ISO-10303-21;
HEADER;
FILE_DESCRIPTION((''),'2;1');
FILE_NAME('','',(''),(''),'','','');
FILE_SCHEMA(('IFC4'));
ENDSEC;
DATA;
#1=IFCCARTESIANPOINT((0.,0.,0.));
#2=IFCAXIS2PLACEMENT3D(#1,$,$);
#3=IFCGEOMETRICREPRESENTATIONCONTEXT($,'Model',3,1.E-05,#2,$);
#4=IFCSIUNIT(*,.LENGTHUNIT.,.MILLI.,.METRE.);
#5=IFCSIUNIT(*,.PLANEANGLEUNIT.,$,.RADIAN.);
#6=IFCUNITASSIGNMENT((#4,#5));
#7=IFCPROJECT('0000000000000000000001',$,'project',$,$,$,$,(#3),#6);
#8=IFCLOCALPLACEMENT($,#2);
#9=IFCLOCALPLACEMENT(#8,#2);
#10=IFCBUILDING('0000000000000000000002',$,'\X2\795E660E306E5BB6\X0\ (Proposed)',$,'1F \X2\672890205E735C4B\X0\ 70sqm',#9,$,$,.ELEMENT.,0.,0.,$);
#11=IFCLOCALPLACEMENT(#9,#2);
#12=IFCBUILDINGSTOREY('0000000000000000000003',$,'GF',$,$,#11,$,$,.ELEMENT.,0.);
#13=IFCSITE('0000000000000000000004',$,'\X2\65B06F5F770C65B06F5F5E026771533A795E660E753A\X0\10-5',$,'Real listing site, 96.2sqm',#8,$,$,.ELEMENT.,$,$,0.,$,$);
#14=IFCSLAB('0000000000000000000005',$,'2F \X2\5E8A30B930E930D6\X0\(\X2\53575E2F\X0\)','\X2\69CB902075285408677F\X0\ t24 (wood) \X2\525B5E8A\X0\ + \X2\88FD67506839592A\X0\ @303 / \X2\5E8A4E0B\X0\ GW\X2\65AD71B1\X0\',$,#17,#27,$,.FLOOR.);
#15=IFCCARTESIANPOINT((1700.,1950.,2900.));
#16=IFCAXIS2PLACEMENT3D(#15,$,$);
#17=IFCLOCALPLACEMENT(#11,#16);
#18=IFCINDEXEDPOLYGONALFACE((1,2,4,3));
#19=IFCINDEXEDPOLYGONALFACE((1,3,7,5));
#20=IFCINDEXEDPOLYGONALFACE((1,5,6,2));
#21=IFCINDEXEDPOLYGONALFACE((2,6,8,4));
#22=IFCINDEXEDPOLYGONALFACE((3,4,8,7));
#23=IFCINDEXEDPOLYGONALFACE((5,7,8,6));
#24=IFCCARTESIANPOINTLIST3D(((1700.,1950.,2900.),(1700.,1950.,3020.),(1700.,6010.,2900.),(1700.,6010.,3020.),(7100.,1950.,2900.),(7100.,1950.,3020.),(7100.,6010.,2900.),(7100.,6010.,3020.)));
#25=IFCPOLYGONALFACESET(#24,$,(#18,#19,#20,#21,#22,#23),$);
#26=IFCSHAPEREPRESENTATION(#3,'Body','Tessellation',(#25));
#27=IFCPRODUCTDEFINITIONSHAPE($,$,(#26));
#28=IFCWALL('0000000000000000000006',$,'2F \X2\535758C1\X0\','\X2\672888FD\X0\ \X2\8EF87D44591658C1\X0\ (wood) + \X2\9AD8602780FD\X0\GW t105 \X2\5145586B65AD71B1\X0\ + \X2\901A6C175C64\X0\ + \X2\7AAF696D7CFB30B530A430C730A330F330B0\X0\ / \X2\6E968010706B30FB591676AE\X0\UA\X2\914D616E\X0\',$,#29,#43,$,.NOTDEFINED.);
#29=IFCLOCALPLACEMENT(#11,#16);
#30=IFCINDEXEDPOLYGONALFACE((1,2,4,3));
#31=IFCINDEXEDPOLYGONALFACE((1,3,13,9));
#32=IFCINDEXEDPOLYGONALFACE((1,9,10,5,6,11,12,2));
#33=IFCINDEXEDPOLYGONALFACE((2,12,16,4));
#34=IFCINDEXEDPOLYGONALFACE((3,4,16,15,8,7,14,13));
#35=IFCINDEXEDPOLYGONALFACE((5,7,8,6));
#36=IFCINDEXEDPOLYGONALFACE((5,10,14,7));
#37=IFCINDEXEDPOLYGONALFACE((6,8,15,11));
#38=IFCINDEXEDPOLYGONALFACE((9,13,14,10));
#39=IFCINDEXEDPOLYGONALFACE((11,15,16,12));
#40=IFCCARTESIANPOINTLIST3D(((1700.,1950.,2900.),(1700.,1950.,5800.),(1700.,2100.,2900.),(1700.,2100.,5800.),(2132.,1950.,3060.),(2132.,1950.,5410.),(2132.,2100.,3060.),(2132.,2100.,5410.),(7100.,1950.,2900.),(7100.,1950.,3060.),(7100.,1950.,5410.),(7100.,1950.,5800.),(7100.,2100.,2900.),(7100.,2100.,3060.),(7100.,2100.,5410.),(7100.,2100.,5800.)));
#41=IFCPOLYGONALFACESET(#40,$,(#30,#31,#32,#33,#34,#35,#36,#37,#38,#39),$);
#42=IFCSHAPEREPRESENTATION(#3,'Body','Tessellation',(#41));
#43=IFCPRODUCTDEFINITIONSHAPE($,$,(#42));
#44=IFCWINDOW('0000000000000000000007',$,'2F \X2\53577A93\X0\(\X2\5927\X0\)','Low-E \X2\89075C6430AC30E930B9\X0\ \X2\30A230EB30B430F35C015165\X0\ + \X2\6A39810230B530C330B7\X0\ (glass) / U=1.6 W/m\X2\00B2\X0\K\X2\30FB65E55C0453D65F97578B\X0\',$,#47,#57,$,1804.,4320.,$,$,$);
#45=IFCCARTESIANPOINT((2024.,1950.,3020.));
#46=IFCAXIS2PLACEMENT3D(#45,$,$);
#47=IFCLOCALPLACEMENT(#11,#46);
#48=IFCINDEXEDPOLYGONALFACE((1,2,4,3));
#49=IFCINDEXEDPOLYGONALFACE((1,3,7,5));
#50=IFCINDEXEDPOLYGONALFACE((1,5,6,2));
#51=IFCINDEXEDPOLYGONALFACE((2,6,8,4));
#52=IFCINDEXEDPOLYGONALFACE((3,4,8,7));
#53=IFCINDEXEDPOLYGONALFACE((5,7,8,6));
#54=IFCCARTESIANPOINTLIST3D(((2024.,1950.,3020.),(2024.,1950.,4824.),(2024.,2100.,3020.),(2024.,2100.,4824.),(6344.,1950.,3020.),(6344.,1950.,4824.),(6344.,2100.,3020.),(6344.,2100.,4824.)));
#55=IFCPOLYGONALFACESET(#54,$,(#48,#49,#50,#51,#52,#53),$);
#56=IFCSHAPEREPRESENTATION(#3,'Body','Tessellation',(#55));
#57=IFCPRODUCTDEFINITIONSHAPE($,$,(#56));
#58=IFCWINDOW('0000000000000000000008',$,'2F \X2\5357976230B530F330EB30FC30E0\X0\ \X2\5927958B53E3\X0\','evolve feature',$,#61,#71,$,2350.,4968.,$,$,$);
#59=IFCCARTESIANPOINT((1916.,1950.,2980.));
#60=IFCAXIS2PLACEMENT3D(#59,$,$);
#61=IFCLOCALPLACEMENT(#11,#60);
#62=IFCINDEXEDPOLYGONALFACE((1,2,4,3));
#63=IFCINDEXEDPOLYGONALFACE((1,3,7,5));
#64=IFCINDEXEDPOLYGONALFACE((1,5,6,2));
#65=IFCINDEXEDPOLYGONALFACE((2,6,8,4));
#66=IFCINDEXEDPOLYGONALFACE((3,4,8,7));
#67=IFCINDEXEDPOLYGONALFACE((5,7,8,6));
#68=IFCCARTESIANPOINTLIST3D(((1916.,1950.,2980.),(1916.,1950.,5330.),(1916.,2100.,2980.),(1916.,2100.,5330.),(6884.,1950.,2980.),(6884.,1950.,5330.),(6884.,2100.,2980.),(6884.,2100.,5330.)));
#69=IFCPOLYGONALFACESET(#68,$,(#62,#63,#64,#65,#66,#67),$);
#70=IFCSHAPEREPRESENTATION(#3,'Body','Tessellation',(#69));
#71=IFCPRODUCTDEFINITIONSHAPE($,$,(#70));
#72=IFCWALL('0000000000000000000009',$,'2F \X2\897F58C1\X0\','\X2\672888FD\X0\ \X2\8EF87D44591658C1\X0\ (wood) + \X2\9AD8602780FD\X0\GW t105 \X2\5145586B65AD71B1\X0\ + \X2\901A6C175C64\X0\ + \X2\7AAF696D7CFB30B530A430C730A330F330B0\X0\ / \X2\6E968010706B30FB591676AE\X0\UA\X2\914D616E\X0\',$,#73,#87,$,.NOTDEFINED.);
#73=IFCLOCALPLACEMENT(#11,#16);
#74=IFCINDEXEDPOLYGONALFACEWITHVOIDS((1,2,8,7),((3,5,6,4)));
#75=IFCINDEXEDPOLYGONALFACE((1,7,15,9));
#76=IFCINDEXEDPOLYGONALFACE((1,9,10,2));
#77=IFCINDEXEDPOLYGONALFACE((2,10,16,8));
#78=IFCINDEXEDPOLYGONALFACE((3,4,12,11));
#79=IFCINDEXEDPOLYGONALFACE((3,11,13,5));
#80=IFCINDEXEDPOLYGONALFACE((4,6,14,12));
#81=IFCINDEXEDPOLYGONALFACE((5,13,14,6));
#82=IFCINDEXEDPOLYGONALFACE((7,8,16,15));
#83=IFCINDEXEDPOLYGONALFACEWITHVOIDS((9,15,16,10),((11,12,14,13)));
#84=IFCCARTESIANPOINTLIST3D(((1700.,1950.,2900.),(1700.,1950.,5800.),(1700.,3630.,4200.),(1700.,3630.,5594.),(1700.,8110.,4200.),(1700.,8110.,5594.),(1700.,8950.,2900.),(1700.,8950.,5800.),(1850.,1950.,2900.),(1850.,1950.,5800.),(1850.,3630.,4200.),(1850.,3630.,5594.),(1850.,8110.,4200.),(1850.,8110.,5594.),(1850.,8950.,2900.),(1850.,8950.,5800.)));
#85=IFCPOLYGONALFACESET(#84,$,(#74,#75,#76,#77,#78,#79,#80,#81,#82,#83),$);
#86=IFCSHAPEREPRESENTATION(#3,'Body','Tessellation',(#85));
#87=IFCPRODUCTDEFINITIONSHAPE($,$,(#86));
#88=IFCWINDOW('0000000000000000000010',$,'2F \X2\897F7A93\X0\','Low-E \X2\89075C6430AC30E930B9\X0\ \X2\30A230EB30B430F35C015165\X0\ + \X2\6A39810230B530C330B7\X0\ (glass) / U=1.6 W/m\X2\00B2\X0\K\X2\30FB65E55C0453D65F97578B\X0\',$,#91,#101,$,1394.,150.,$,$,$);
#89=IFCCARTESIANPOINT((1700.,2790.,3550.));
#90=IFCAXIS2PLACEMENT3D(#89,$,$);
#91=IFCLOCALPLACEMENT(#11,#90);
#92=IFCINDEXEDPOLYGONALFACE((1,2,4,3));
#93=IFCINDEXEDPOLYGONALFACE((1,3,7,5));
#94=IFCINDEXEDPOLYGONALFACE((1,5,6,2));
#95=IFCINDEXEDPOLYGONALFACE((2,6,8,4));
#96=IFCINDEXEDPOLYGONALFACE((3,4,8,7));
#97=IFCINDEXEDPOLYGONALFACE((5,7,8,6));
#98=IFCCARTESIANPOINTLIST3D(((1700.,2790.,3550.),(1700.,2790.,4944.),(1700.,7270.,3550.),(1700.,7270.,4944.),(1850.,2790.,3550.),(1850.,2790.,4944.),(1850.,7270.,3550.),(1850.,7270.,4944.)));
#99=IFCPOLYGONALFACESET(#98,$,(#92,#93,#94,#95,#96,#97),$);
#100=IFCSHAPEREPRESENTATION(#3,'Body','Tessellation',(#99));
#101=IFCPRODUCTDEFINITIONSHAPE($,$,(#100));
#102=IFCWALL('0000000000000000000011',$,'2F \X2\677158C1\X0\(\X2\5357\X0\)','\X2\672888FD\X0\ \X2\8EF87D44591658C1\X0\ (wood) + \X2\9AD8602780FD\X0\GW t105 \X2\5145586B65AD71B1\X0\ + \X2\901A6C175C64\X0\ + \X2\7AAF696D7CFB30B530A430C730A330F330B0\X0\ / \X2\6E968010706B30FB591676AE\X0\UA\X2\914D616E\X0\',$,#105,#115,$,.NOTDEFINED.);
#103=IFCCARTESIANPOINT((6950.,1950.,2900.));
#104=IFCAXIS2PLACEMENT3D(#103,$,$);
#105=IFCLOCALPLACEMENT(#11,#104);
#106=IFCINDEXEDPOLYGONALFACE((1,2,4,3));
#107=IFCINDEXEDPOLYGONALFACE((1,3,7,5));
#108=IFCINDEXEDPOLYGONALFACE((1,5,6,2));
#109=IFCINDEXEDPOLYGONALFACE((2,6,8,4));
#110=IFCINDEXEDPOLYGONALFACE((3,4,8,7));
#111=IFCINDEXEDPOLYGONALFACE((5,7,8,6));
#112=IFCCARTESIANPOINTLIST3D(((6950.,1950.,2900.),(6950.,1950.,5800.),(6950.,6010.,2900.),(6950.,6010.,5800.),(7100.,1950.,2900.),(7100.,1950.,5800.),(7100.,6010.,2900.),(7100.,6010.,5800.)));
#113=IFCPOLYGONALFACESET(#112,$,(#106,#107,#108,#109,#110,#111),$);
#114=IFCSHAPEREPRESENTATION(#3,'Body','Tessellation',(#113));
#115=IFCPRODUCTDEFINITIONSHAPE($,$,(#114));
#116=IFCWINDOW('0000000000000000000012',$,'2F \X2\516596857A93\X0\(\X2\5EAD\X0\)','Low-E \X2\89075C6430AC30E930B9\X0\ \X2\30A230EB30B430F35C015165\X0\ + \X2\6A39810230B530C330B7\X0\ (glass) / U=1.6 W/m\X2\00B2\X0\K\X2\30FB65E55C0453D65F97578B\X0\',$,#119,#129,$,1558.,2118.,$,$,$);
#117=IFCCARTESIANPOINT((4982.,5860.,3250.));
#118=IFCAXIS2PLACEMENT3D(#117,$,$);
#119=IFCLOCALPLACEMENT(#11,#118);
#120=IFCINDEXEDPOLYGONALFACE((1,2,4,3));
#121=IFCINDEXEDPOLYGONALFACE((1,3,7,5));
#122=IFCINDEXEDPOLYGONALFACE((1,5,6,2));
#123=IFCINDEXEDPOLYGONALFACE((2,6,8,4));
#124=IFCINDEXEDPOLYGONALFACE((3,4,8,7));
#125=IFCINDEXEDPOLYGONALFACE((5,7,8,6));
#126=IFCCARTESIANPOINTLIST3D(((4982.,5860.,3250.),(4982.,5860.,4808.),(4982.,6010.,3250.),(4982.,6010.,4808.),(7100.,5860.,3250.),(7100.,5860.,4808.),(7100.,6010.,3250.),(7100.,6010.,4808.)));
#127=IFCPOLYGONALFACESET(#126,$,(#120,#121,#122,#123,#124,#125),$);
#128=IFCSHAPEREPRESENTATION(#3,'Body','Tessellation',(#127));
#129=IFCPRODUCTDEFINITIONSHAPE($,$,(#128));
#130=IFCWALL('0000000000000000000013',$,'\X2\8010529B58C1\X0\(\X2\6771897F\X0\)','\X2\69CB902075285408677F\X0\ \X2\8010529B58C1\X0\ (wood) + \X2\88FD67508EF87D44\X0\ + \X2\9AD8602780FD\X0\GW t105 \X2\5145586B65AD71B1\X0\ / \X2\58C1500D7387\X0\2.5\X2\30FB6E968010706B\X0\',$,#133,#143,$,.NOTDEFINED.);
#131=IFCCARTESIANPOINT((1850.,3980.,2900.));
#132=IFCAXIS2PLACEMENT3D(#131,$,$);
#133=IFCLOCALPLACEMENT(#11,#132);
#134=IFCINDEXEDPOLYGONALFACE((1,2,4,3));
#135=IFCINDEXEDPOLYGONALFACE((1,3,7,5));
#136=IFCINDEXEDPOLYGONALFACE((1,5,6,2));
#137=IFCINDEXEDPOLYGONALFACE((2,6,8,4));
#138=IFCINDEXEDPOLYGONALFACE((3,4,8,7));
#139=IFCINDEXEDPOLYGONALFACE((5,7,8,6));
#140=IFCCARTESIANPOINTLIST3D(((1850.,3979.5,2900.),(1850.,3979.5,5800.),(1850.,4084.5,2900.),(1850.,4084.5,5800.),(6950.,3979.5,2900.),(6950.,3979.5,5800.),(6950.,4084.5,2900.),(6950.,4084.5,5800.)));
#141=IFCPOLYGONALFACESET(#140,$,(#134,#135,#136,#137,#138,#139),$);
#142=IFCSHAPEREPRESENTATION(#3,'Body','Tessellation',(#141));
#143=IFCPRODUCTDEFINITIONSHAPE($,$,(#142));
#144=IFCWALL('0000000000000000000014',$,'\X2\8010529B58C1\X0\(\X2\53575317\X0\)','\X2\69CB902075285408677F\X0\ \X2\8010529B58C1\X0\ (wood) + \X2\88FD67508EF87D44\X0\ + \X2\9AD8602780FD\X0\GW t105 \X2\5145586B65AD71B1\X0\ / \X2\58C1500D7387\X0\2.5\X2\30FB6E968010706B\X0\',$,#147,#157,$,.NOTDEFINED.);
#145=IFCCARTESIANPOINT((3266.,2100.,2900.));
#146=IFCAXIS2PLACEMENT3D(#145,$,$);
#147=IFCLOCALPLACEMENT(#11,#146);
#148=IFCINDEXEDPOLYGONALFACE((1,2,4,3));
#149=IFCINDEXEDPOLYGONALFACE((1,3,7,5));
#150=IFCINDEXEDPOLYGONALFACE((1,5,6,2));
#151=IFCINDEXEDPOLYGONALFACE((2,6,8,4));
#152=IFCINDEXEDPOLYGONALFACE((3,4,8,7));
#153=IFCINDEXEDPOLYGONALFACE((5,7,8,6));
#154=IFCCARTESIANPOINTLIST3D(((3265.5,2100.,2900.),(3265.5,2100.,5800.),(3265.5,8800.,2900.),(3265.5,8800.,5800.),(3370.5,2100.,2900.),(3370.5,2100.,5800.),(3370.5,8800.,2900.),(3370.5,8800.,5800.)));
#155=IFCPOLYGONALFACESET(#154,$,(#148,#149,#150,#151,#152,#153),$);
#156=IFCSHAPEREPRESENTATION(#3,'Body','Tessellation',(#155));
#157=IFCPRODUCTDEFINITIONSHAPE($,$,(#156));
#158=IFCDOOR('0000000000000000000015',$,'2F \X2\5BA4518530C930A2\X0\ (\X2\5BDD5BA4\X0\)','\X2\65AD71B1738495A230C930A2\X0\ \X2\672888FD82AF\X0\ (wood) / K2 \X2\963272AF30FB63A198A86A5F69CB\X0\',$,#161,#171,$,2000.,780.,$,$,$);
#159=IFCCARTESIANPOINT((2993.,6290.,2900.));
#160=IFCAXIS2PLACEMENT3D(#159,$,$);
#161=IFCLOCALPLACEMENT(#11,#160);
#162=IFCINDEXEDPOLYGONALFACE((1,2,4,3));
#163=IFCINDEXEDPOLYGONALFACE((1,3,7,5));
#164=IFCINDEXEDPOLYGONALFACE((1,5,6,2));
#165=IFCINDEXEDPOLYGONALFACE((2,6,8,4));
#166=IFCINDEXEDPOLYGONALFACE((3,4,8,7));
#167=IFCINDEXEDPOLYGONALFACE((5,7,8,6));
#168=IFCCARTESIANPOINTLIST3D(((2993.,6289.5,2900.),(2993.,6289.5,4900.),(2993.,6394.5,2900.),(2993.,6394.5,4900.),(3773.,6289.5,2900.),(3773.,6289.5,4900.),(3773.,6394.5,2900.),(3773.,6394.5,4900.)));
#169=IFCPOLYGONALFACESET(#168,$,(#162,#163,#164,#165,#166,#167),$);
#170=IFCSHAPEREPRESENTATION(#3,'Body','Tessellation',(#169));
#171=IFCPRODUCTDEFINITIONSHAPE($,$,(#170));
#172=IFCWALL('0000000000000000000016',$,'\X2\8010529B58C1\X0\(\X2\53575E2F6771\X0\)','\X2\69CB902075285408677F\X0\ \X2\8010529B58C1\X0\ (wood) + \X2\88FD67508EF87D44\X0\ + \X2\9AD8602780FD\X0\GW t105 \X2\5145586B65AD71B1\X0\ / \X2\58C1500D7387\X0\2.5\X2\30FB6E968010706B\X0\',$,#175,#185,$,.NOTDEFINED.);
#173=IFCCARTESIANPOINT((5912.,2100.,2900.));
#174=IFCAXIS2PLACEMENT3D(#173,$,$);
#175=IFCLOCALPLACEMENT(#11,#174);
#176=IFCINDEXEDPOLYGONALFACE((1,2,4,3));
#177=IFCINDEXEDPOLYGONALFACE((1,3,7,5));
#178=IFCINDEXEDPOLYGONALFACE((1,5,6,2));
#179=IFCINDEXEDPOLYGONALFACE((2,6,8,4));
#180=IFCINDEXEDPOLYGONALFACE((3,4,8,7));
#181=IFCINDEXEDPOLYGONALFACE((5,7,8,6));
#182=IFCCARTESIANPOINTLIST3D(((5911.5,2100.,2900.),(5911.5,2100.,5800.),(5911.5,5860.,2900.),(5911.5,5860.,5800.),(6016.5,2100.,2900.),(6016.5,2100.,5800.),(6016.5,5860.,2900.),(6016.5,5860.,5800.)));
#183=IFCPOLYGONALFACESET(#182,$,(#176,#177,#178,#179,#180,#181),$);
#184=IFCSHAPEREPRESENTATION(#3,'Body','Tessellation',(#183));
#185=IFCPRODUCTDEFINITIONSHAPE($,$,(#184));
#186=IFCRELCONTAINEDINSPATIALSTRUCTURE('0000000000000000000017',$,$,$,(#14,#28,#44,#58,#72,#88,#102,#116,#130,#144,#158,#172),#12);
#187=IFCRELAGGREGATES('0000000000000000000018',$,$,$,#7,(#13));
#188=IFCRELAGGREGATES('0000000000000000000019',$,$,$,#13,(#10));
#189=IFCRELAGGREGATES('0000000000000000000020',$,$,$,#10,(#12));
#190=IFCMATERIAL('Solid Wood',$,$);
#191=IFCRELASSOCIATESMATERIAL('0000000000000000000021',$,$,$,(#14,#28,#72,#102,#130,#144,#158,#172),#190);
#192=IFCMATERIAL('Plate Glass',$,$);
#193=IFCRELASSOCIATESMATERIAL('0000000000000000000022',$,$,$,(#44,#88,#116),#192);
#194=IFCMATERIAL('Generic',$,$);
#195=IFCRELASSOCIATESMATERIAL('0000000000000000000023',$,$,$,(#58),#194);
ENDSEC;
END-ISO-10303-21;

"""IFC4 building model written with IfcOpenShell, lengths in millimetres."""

from ifc_helpers import new_model, si_unit, frame, frame_2d, origin, place, context, project, spatial, rectangle, extrude, material, element, fill, save


model = new_model("IFC4")

# Units and contexts
model_context = context("Model", 3, precision=1e-05, world=origin())
ifc_project = project(units=[si_unit("LENGTHUNIT", "METRE", prefix="MILLI"), si_unit("PLANEANGLEUNIT", "RADIAN")], contexts=[model_context])

# Site, building, storey
site_placement = place(None, origin())
site = spatial("IfcSite", under=ifc_project, at=site_placement, Name="新潟県新潟市東区神明町10-5", ObjectType="Real listing site, 96.2sqm", CompositionType="ELEMENT", RefElevation=0.0)
building_placement = place(site_placement, origin())
building = spatial("IfcBuilding", under=site, at=building_placement, Name="神明の家 (Proposed)", ObjectType="1F 木造平屋 70sqm", CompositionType="ELEMENT", ElevationOfRefHeight=0.0, ElevationOfTerrain=0.0)
storey_placement = place(building_placement, origin())
storey = spatial("IfcBuildingStorey", under=building, at=storey_placement, Name="GF", CompositionType="ELEMENT", Elevation=0.0)

# Slab
ifc_material_1 = material(Name="Solid Wood")
slab_placement = place(storey_placement, frame((1700.0, 1950.0, 2900.0)))
element("IfcSlab", 1, at=slab_placement, inside=storey, material=ifc_material_1, Name="2F 床スラブ(南帯)", Description="構造用合板 t24 (wood) 剛床 + 製材根太 @303 / 床下 GW断熱", PredefinedType="FLOOR", context=model_context, shape_type="SweptSolid", body=[
    extrude(rectangle(XDim=5400.0, YDim=4060.0, at=frame_2d((2700.0, 2030.0))), frame((1700.0, 1950.0, 2900.0)), (0.0, 0.0, 1.0), 120.0),
])

# Wall, openings, windows
wall_1_placement = place(storey_placement, frame((1700.0, 1950.0, 2900.0)))
wall_1 = element("IfcWall", 2, at=wall_1_placement, inside=storey, material=ifc_material_1, Name="2F 南壁", Description="木製 軸組外壁 (wood) + 高性能GW t105 充填断熱 + 通気層 + 窯業系サイディング / 準耐火・外皮UA配慮", PredefinedType="NOTDEFINED", context=model_context, shape_type="SweptSolid", body=[
    extrude(rectangle(XDim=5400.0, YDim=150.0, at=frame_2d((2700.0, 75.0))), frame((1700.0, 1950.0, 2900.0)), (0.0, 0.0, 1.0), 2900.0),
])
opening_1_placement = place(storey_placement, frame((2024.0, 1950.0, 3020.0)))
opening_1 = element("IfcOpeningElement", 3, at=opening_1_placement, cuts=wall_1, PredefinedType="NOTDEFINED", context=model_context, shape_type="SweptSolid", body=[
    extrude(rectangle(XDim=4320.0, YDim=150.0, at=frame_2d((2160.0, 75.0))), frame((2024.0, 1950.0, 3020.0)), (0.0, 0.0, 1.0), 1804.0),
])
opening_2_placement = place(storey_placement, frame((1916.0, 1950.0, 2980.0)))
opening_2 = element("IfcOpeningElement", 4, at=opening_2_placement, cuts=wall_1, PredefinedType="NOTDEFINED", context=model_context, shape_type="SweptSolid", body=[
    extrude(rectangle(XDim=4968.0, YDim=150.0, at=frame_2d((2484.0, 75.0))), frame((1916.0, 1950.0, 2980.0)), (0.0, 0.0, 1.0), 2350.0),
])
ifc_material_2 = material(Name="Plate Glass")
window_1_placement = place(storey_placement, frame((2024.0, 1950.0, 3020.0)))
window_1 = element("IfcWindow", 5, at=window_1_placement, inside=storey, material=ifc_material_2, Name="2F 南窓(大)", Description="Low-E 複層ガラス アルゴン封入 + 樹脂サッシ (glass) / U=1.6 W/m²K・日射取得型", OverallHeight=1804.0, OverallWidth=4320.0, context=model_context, shape_type="SweptSolid", body=[
    extrude(rectangle(XDim=4320.0, YDim=150.0, at=frame_2d((2160.0, 75.0))), frame((2024.0, 1950.0, 3020.0)), (0.0, 0.0, 1.0), 1804.0),
])
fill(opening_1, window_1)
ifc_material_3 = material(Name="Generic")
window_2_placement = place(storey_placement, frame((1916.0, 1950.0, 2980.0)))
window_2 = element("IfcWindow", 6, at=window_2_placement, inside=storey, material=ifc_material_3, Name="2F 南面サンルーム 大開口", Description="evolve feature", OverallHeight=2350.0, OverallWidth=4968.0, context=model_context, shape_type="SweptSolid", body=[
    extrude(rectangle(XDim=4968.0, YDim=150.0, at=frame_2d((2484.0, 75.0))), frame((1916.0, 1950.0, 2980.0)), (0.0, 0.0, 1.0), 2350.0),
])
fill(opening_2, window_2)

# Walls, openings, windows
wall_2_placement = place(storey_placement, frame((1700.0, 1950.0, 2900.0)))
wall_2 = element("IfcWall", 7, at=wall_2_placement, inside=storey, material=ifc_material_1, Name="2F 西壁", Description="木製 軸組外壁 (wood) + 高性能GW t105 充填断熱 + 通気層 + 窯業系サイディング / 準耐火・外皮UA配慮", PredefinedType="NOTDEFINED", context=model_context, shape_type="SweptSolid", body=[
    extrude(rectangle(XDim=150.0, YDim=7000.0, at=frame_2d((75.0, 3500.0))), frame((1700.0, 1950.0, 2900.0)), (0.0, 0.0, 1.0), 2900.0),
])
opening_3_placement = place(storey_placement, frame((1700.0, 2790.0, 3550.0)))
opening_3 = element("IfcOpeningElement", 8, at=opening_3_placement, cuts=wall_2, PredefinedType="NOTDEFINED", context=model_context, shape_type="SweptSolid", body=[
    extrude(rectangle(XDim=150.0, YDim=4480.0, at=frame_2d((75.0, 2240.0))), frame((1700.0, 2790.0, 3550.0)), (0.0, 0.0, 1.0), 1394.0),
])
window_3_placement = place(storey_placement, frame((1700.0, 2790.0, 3550.0)))
window_3 = element("IfcWindow", 9, at=window_3_placement, inside=storey, material=ifc_material_2, Name="2F 西窓", Description="Low-E 複層ガラス アルゴン封入 + 樹脂サッシ (glass) / U=1.6 W/m²K・日射取得型", OverallHeight=1394.0, OverallWidth=150.0, context=model_context, shape_type="SweptSolid", body=[
    extrude(rectangle(XDim=150.0, YDim=4480.0, at=frame_2d((75.0, 2240.0))), frame((1700.0, 2790.0, 3550.0)), (0.0, 0.0, 1.0), 1394.0),
])
fill(opening_3, window_3)
wall_3_placement = place(storey_placement, frame((6950.0, 1950.0, 2900.0)))
wall_3 = element("IfcWall", 10, at=wall_3_placement, inside=storey, material=ifc_material_1, Name="2F 東壁(南)", Description="木製 軸組外壁 (wood) + 高性能GW t105 充填断熱 + 通気層 + 窯業系サイディング / 準耐火・外皮UA配慮", PredefinedType="NOTDEFINED", context=model_context, shape_type="SweptSolid", body=[
    extrude(rectangle(XDim=150.0, YDim=4060.0, at=frame_2d((75.0, 2030.0))), frame((6950.0, 1950.0, 2900.0)), (0.0, 0.0, 1.0), 2900.0),
])
opening_4_placement = place(storey_placement, frame((4982.0, 5860.0, 3250.0)))
opening_4 = element("IfcOpeningElement", 11, at=opening_4_placement, cuts=wall_3, PredefinedType="NOTDEFINED", context=model_context, shape_type="SweptSolid", body=[
    extrude(rectangle(XDim=2118.0, YDim=150.0, at=frame_2d((1059.0, 75.0))), frame((4982.0, 5860.0, 3250.0)), (0.0, 0.0, 1.0), 1558.0),
])
window_4_placement = place(storey_placement, frame((4982.0, 5860.0, 3250.0)))
window_4 = element("IfcWindow", 12, at=window_4_placement, inside=storey, material=ifc_material_2, Name="2F 入隅窓(庭)", Description="Low-E 複層ガラス アルゴン封入 + 樹脂サッシ (glass) / U=1.6 W/m²K・日射取得型", OverallHeight=1558.0, OverallWidth=2118.0, context=model_context, shape_type="SweptSolid", body=[
    extrude(rectangle(XDim=2118.0, YDim=150.0, at=frame_2d((1059.0, 75.0))), frame((4982.0, 5860.0, 3250.0)), (0.0, 0.0, 1.0), 1558.0),
])
fill(opening_4, window_4)

# Wall
wall_4_placement = place(storey_placement, frame((1850.0, 3980.0, 2900.0)))
element("IfcWall", 13, at=wall_4_placement, inside=storey, material=ifc_material_1, Name="耐力壁(東西)", Description="構造用合板 耐力壁 (wood) + 製材軸組 + 高性能GW t105 充填断熱 / 壁倍率2.5・準耐火", PredefinedType="NOTDEFINED", context=model_context, shape_type="SweptSolid", body=[
    extrude(rectangle(XDim=5100.0, YDim=105.0, at=frame_2d((2550.0, 52.0))), frame((1850.0, 3980.0, 2900.0)), (0.0, 0.0, 1.0), 2900.0),
])

# Wall, opening, door
wall_5_placement = place(storey_placement, frame((3266.0, 2100.0, 2900.0)))
wall_5 = element("IfcWall", 14, at=wall_5_placement, inside=storey, material=ifc_material_1, Name="耐力壁(南北)", Description="構造用合板 耐力壁 (wood) + 製材軸組 + 高性能GW t105 充填断熱 / 壁倍率2.5・準耐火", PredefinedType="NOTDEFINED", context=model_context, shape_type="SweptSolid", body=[
    extrude(rectangle(XDim=105.0, YDim=6700.0, at=frame_2d((52.0, 3350.0))), frame((3266.0, 2100.0, 2900.0)), (0.0, 0.0, 1.0), 2900.0),
])
opening_5_placement = place(storey_placement, frame((2993.0, 6290.0, 2900.0)))
opening_5 = element("IfcOpeningElement", 15, at=opening_5_placement, cuts=wall_5, PredefinedType="NOTDEFINED", context=model_context, shape_type="SweptSolid", body=[
    extrude(rectangle(XDim=780.0, YDim=105.0, at=frame_2d((390.0, 52.0))), frame((2993.0, 6290.0, 2900.0)), (0.0, 0.0, 1.0), 2000.0),
])
door_placement = place(storey_placement, frame((2993.0, 6290.0, 2900.0)))
door = element("IfcDoor", 16, at=door_placement, inside=storey, material=ifc_material_1, Name="2F 室内ドア (寝室)", Description="断熱玄関ドア 木製芯 (wood) / K2 防犯・採風機構", OverallHeight=2000.0, OverallWidth=780.0, context=model_context, shape_type="SweptSolid", body=[
    extrude(rectangle(XDim=780.0, YDim=105.0, at=frame_2d((390.0, 52.0))), frame((2993.0, 6290.0, 2900.0)), (0.0, 0.0, 1.0), 2000.0),
])
fill(opening_5, door)

# Wall
wall_6_placement = place(storey_placement, frame((5912.0, 2100.0, 2900.0)))
element("IfcWall", 17, at=wall_6_placement, inside=storey, material=ifc_material_1, Name="耐力壁(南帯東)", Description="構造用合板 耐力壁 (wood) + 製材軸組 + 高性能GW t105 充填断熱 / 壁倍率2.5・準耐火", PredefinedType="NOTDEFINED", context=model_context, shape_type="SweptSolid", body=[
    extrude(rectangle(XDim=105.0, YDim=3760.0, at=frame_2d((52.0, 1880.0))), frame((5912.0, 2100.0, 2900.0)), (0.0, 0.0, 1.0), 2900.0),
])

save(model, "model.ifc")
